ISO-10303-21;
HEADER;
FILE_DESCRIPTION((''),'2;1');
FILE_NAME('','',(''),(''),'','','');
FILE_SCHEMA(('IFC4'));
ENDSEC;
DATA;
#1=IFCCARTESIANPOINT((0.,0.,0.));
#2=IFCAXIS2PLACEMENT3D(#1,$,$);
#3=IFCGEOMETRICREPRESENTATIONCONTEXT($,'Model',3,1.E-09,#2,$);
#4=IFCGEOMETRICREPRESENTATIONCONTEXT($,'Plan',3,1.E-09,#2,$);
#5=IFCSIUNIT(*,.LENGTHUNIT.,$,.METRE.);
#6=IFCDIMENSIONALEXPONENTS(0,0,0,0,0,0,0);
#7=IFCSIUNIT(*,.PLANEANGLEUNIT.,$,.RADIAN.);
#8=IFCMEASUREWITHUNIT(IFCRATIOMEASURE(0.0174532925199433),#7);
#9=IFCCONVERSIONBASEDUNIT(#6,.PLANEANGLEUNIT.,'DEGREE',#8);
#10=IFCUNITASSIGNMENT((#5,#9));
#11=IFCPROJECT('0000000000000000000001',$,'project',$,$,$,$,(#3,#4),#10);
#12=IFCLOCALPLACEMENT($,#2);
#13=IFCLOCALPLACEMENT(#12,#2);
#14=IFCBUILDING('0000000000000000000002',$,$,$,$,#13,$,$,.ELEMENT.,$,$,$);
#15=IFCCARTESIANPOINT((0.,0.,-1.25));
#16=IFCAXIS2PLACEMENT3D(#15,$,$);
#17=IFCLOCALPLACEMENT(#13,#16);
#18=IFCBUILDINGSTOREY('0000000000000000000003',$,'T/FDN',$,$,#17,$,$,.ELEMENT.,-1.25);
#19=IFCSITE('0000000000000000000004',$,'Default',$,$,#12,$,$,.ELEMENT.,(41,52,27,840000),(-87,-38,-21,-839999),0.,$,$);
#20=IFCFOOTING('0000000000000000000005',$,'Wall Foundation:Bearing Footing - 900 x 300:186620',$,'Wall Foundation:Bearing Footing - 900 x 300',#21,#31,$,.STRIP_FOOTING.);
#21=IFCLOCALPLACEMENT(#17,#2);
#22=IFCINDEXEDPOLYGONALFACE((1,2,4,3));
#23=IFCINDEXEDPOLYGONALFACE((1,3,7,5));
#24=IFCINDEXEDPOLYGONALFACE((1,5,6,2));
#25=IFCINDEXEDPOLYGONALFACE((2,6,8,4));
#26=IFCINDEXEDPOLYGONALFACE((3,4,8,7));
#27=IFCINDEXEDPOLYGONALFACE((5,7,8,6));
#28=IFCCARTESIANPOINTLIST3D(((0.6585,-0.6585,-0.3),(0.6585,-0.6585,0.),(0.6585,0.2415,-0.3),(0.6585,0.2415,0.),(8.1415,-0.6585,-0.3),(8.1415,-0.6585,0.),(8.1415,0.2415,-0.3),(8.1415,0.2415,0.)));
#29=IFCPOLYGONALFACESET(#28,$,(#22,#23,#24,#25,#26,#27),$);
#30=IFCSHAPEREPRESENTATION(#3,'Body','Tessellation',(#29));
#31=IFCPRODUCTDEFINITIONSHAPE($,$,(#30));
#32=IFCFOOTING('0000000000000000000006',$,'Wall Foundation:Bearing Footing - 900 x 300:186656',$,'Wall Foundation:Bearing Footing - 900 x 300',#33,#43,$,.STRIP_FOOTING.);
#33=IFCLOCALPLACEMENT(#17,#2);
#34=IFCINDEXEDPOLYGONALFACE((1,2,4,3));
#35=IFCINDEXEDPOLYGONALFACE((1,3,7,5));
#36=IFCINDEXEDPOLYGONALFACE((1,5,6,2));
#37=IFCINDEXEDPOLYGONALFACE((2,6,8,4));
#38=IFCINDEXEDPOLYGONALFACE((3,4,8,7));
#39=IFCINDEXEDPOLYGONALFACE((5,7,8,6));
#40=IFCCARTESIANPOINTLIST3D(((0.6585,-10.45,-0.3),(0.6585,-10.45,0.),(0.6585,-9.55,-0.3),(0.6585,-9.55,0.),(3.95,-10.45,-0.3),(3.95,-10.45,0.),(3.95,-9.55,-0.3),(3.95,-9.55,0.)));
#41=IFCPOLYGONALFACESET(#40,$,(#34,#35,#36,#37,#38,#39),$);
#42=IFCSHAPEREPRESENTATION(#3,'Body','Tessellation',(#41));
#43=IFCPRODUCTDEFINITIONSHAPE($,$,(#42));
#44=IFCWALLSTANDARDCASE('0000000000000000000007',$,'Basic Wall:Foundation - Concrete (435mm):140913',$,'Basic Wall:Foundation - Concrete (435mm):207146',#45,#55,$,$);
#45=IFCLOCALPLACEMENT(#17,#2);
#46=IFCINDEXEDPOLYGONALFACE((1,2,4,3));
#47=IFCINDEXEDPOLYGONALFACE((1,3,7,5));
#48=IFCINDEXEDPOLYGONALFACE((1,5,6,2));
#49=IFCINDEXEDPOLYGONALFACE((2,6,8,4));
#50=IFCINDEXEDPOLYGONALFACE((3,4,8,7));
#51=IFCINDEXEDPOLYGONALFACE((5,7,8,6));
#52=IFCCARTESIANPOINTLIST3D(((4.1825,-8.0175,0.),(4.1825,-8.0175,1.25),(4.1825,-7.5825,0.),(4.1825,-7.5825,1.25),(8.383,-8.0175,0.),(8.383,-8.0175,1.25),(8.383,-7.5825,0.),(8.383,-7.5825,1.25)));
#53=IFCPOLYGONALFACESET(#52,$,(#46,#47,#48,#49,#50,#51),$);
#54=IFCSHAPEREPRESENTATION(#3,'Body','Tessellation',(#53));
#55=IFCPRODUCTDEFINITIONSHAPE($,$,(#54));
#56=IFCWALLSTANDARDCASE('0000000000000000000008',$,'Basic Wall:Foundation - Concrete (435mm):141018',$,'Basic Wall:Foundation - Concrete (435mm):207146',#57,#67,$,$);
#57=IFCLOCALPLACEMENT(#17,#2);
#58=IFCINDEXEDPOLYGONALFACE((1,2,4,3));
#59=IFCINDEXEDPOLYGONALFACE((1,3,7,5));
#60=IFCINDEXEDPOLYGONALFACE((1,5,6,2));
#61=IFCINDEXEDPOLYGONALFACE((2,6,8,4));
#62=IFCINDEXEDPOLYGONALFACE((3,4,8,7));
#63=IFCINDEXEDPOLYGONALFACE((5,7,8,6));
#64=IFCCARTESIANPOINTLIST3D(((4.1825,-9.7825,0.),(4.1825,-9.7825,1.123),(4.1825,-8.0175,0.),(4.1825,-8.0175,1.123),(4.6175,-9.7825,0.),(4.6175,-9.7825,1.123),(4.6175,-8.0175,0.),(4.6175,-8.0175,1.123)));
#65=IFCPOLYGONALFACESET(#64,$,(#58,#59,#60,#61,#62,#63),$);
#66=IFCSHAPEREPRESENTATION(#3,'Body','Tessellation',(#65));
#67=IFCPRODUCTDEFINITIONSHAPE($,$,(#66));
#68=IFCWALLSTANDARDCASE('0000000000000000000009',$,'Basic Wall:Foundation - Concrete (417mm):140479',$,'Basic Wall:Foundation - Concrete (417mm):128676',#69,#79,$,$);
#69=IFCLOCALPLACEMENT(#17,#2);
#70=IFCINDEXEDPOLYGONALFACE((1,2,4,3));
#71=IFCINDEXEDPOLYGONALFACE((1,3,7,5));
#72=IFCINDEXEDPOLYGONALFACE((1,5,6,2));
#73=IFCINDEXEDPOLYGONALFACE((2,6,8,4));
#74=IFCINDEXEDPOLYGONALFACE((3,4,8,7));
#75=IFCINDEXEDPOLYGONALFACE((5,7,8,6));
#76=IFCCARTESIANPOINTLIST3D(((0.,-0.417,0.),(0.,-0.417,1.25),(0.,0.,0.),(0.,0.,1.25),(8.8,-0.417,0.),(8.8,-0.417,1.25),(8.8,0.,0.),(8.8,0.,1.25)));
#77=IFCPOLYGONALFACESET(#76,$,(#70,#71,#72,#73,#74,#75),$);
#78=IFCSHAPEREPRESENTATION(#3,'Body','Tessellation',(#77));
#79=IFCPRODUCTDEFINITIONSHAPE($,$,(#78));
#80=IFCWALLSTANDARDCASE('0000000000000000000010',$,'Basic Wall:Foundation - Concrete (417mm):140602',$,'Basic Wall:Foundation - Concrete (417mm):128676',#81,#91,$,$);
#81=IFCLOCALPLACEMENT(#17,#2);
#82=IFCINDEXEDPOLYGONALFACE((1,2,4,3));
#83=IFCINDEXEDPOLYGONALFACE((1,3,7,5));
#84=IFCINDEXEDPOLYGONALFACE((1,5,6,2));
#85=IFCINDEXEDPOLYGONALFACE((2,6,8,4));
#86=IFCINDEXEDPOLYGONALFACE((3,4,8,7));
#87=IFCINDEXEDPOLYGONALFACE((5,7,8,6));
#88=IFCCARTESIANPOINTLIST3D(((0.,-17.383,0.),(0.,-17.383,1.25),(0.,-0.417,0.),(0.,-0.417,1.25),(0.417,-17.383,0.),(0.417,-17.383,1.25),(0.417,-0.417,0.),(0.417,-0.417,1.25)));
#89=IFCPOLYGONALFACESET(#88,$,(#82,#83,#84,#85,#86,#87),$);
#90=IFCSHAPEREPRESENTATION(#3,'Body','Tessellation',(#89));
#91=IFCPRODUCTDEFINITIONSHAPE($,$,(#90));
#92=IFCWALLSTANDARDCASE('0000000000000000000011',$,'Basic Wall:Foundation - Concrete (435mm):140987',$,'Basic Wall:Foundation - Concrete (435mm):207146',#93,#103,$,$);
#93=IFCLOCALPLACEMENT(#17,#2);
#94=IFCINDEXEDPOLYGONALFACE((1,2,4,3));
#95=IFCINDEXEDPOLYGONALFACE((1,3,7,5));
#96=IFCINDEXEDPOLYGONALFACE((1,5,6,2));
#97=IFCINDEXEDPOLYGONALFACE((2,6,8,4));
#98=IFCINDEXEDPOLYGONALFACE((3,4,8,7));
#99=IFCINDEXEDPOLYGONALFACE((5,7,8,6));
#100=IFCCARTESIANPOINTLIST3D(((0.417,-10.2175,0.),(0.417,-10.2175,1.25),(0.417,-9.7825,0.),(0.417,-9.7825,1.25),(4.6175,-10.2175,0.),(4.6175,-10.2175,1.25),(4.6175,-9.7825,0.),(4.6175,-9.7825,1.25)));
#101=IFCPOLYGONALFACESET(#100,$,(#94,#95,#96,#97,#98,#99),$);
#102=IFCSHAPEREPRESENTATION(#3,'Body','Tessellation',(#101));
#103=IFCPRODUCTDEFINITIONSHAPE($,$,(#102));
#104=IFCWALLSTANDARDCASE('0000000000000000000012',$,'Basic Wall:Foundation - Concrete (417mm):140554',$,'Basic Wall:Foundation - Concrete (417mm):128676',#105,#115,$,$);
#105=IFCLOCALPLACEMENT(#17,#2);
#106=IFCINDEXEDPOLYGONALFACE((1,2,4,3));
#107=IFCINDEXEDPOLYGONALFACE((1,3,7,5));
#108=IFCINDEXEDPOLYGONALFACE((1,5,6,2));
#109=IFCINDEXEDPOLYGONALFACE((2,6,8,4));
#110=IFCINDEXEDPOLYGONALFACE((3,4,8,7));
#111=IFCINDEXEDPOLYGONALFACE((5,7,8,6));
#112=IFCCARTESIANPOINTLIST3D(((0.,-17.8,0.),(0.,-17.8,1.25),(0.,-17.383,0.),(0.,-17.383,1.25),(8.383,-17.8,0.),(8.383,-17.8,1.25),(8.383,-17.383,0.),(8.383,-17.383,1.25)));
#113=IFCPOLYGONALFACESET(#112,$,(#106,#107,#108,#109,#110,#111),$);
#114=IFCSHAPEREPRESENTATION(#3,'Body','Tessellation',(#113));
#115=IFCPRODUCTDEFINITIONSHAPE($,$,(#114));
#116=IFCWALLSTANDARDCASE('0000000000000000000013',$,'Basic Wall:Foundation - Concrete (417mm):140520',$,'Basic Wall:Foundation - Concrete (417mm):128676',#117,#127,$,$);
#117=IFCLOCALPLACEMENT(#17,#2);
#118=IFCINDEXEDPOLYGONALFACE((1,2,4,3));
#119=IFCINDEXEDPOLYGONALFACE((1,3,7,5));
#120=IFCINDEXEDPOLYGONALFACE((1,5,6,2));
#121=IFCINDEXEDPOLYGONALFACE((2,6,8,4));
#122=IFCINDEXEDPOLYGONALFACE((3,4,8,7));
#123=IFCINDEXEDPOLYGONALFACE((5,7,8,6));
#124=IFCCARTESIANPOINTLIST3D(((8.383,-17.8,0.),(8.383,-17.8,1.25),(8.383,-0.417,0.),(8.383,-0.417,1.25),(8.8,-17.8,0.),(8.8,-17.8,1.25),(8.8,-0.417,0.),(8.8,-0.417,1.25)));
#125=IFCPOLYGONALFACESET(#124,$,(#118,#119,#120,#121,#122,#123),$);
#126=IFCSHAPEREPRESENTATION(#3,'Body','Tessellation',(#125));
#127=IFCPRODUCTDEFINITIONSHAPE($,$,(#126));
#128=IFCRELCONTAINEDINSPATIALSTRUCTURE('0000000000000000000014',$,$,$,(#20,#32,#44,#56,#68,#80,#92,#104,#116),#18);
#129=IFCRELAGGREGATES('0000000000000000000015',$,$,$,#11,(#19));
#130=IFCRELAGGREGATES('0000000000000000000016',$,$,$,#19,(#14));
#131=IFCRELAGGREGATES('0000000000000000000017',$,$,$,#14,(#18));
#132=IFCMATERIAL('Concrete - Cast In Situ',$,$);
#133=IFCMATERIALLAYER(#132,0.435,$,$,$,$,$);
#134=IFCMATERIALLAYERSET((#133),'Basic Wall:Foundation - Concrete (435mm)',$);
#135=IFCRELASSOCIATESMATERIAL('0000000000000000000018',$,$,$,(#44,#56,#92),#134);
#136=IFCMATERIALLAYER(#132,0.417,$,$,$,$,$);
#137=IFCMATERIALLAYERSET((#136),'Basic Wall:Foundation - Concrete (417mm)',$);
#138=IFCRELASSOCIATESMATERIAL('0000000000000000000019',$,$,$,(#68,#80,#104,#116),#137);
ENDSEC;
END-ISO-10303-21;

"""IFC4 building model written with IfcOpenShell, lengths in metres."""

from ifc_helpers import new_model, entity, si_unit, converted_unit, frame, frame_2d, origin, origin_2d_with_axis, place, context, project, spatial, rectangle, extrude, material, layer, layer_set, layer_usage, element, save


model = new_model("IFC4")

# Units and contexts
model_context = context("Model", 3, precision=1e-09, world=origin())
plan_context = context("Plan", 3, precision=1e-09, world=origin())
ifc_project = project(units=[si_unit("LENGTHUNIT", "METRE"), converted_unit("PLANEANGLEUNIT", "DEGREE", entity("IfcRatioMeasure", 0.0174532925199433), si_unit("PLANEANGLEUNIT", "RADIAN"), dimensions=[0, 0, 0, 0, 0, 0, 0])], contexts=[model_context, plan_context])

# Site, building, storey
site_placement = place(None, origin())
site = spatial("IfcSite", under=ifc_project, at=site_placement, Name="Default", CompositionType="ELEMENT", RefLatitude=(41, 52, 27, 840000), RefLongitude=(-87, -38, -21, -839999), RefElevation=0.0)
building_placement = place(site_placement, origin())
building = spatial("IfcBuilding", under=site, at=building_placement, CompositionType="ELEMENT")
storey_placement = place(building_placement, frame((0.0, 0.0, -1.25)))
storey = spatial("IfcBuildingStorey", under=building, at=storey_placement, Name="T/FDN", CompositionType="ELEMENT", Elevation=-1.25)

# Footings
footing_1_placement = place(storey_placement, origin())
element("IfcFooting", 1, at=footing_1_placement, inside=storey, Name="Wall Foundation:Bearing Footing - 900 x 300:186620", ObjectType="Wall Foundation:Bearing Footing - 900 x 300", PredefinedType="STRIP_FOOTING", context=model_context, shape_type="SweptSolid", body=[
    extrude(rectangle(XDim=7.483, YDim=0.9, at=origin_2d_with_axis()), frame((4.4, -0.2085, -0.3), z_axis=(0.0, 0.0, 1.0), x_axis=(-1.0, 0.0, 0.0)), (0.0, 0.0, 1.0), 0.3),
])
footing_2_placement = place(storey_placement, origin())
element("IfcFooting", 2, at=footing_2_placement, inside=storey, Name="Wall Foundation:Bearing Footing - 900 x 300:186656", ObjectType="Wall Foundation:Bearing Footing - 900 x 300", PredefinedType="STRIP_FOOTING", context=model_context, shape_type="SweptSolid", body=[
    extrude(rectangle(XDim=3.2915, YDim=0.9, at=origin_2d_with_axis()), frame((2.3043, -10.0, -0.3)), (0.0, 0.0, 1.0), 0.3),
])

# Walls
ifc_material = material(Name="Concrete - Cast In Situ")
ifc_layer_1 = layer(ifc_material, 0.435)
ifc_layer_set_1 = layer_set([ifc_layer_1], Name="Basic Wall:Foundation - Concrete (435mm)")
ifc_layer_usage_1 = layer_usage(ifc_layer_set_1, "AXIS2", "NEGATIVE", 0.2175)
wall_1_placement = place(storey_placement, frame((8.383, -7.8, 0.0), z_axis=(0.0, 0.0, 1.0), x_axis=(-1.0, 0.0, 0.0)))
element("IfcWallStandardCase", 3, at=wall_1_placement, inside=storey, material=ifc_layer_usage_1, Name="Basic Wall:Foundation - Concrete (435mm):140913", ObjectType="Basic Wall:Foundation - Concrete (435mm):207146", context=model_context, shape_type="SweptSolid", body=[
    extrude(rectangle(XDim=4.2005, YDim=0.435, at=frame_2d((2.1002, 0.0), x_axis=(-1.0, 0.0))), origin(), (0.0, 0.0, 1.0), 1.25),
])
ifc_layer_usage_2 = layer_usage(ifc_layer_set_1, "AXIS2", "NEGATIVE", 0.2175)
wall_2_placement = place(storey_placement, frame((4.4, -9.7825, 0.0), z_axis=(0.0, 0.0, 1.0), x_axis=(0.0, 1.0, 0.0)))
element("IfcWallStandardCase", 4, at=wall_2_placement, inside=storey, material=ifc_layer_usage_2, Name="Basic Wall:Foundation - Concrete (435mm):141018", ObjectType="Basic Wall:Foundation - Concrete (435mm):207146", context=model_context, shape_type="SweptSolid", body=[
    extrude(rectangle(XDim=1.765, YDim=0.435, at=frame_2d((0.8825, 0.0), x_axis=(-1.0, 0.0))), origin(), (0.0, 0.0, 1.0), 1.123),
])
ifc_layer_2 = layer(ifc_material, 0.417)
ifc_layer_set_2 = layer_set([ifc_layer_2], Name="Basic Wall:Foundation - Concrete (417mm)")
ifc_layer_usage_3 = layer_usage(ifc_layer_set_2, "AXIS2", "NEGATIVE", 0.2085)
wall_3_placement = place(storey_placement, frame((0.0, -0.2085, 0.0)))
element("IfcWallStandardCase", 5, at=wall_3_placement, inside=storey, material=ifc_layer_usage_3, Name="Basic Wall:Foundation - Concrete (417mm):140479", ObjectType="Basic Wall:Foundation - Concrete (417mm):128676", context=model_context, shape_type="SweptSolid", body=[
    extrude(rectangle(XDim=8.8, YDim=0.417, at=frame_2d((4.4, 0.0), x_axis=(-1.0, 0.0))), origin(), (0.0, 0.0, 1.0), 1.25),
])
ifc_layer_usage_4 = layer_usage(ifc_layer_set_2, "AXIS2", "NEGATIVE", 0.2085)
wall_4_placement = place(storey_placement, frame((0.2085, -17.383, 0.0), z_axis=(0.0, 0.0, 1.0), x_axis=(0.0, 1.0, 0.0)))
element("IfcWallStandardCase", 6, at=wall_4_placement, inside=storey, material=ifc_layer_usage_4, Name="Basic Wall:Foundation - Concrete (417mm):140602", ObjectType="Basic Wall:Foundation - Concrete (417mm):128676", context=model_context, shape_type="SweptSolid", body=[
    extrude(rectangle(XDim=16.966, YDim=0.417, at=frame_2d((8.483, 0.0), x_axis=(-1.0, 0.0))), origin(), (0.0, 0.0, 1.0), 1.25),
])
ifc_layer_usage_5 = layer_usage(ifc_layer_set_1, "AXIS2", "NEGATIVE", 0.2175)
wall_5_placement = place(storey_placement, frame((0.417, -10.0, 0.0)))
element("IfcWallStandardCase", 7, at=wall_5_placement, inside=storey, material=ifc_layer_usage_5, Name="Basic Wall:Foundation - Concrete (435mm):140987", ObjectType="Basic Wall:Foundation - Concrete (435mm):207146", context=model_context, shape_type="SweptSolid", body=[
    extrude(rectangle(XDim=4.2005, YDim=0.435, at=frame_2d((2.1002, 0.0), x_axis=(-1.0, 0.0))), origin(), (0.0, 0.0, 1.0), 1.25),
])
ifc_layer_usage_6 = layer_usage(ifc_layer_set_2, "AXIS2", "NEGATIVE", 0.2085)
wall_6_placement = place(storey_placement, frame((8.383, -17.5915, 0.0), z_axis=(0.0, 0.0, 1.0), x_axis=(-1.0, 0.0, 0.0)))
element("IfcWallStandardCase", 8, at=wall_6_placement, inside=storey, material=ifc_layer_usage_6, Name="Basic Wall:Foundation - Concrete (417mm):140554", ObjectType="Basic Wall:Foundation - Concrete (417mm):128676", context=model_context, shape_type="SweptSolid", body=[
    extrude(rectangle(XDim=8.383, YDim=0.417, at=frame_2d((4.1915, 0.0), x_axis=(-1.0, 0.0))), origin(), (0.0, 0.0, 1.0), 1.25),
])
ifc_layer_usage_7 = layer_usage(ifc_layer_set_2, "AXIS2", "NEGATIVE", 0.2085)
wall_7_placement = place(storey_placement, frame((8.5915, -0.417, 0.0), z_axis=(0.0, 0.0, 1.0), x_axis=(0.0, -1.0, 0.0)))
element("IfcWallStandardCase", 9, at=wall_7_placement, inside=storey, material=ifc_layer_usage_7, Name="Basic Wall:Foundation - Concrete (417mm):140520", ObjectType="Basic Wall:Foundation - Concrete (417mm):128676", context=model_context, shape_type="SweptSolid", body=[
    extrude(rectangle(XDim=17.383, YDim=0.417, at=frame_2d((8.6915, 0.0), x_axis=(-1.0, 0.0))), origin(), (0.0, 0.0, 1.0), 1.25),
])

save(model, "model.ifc")
